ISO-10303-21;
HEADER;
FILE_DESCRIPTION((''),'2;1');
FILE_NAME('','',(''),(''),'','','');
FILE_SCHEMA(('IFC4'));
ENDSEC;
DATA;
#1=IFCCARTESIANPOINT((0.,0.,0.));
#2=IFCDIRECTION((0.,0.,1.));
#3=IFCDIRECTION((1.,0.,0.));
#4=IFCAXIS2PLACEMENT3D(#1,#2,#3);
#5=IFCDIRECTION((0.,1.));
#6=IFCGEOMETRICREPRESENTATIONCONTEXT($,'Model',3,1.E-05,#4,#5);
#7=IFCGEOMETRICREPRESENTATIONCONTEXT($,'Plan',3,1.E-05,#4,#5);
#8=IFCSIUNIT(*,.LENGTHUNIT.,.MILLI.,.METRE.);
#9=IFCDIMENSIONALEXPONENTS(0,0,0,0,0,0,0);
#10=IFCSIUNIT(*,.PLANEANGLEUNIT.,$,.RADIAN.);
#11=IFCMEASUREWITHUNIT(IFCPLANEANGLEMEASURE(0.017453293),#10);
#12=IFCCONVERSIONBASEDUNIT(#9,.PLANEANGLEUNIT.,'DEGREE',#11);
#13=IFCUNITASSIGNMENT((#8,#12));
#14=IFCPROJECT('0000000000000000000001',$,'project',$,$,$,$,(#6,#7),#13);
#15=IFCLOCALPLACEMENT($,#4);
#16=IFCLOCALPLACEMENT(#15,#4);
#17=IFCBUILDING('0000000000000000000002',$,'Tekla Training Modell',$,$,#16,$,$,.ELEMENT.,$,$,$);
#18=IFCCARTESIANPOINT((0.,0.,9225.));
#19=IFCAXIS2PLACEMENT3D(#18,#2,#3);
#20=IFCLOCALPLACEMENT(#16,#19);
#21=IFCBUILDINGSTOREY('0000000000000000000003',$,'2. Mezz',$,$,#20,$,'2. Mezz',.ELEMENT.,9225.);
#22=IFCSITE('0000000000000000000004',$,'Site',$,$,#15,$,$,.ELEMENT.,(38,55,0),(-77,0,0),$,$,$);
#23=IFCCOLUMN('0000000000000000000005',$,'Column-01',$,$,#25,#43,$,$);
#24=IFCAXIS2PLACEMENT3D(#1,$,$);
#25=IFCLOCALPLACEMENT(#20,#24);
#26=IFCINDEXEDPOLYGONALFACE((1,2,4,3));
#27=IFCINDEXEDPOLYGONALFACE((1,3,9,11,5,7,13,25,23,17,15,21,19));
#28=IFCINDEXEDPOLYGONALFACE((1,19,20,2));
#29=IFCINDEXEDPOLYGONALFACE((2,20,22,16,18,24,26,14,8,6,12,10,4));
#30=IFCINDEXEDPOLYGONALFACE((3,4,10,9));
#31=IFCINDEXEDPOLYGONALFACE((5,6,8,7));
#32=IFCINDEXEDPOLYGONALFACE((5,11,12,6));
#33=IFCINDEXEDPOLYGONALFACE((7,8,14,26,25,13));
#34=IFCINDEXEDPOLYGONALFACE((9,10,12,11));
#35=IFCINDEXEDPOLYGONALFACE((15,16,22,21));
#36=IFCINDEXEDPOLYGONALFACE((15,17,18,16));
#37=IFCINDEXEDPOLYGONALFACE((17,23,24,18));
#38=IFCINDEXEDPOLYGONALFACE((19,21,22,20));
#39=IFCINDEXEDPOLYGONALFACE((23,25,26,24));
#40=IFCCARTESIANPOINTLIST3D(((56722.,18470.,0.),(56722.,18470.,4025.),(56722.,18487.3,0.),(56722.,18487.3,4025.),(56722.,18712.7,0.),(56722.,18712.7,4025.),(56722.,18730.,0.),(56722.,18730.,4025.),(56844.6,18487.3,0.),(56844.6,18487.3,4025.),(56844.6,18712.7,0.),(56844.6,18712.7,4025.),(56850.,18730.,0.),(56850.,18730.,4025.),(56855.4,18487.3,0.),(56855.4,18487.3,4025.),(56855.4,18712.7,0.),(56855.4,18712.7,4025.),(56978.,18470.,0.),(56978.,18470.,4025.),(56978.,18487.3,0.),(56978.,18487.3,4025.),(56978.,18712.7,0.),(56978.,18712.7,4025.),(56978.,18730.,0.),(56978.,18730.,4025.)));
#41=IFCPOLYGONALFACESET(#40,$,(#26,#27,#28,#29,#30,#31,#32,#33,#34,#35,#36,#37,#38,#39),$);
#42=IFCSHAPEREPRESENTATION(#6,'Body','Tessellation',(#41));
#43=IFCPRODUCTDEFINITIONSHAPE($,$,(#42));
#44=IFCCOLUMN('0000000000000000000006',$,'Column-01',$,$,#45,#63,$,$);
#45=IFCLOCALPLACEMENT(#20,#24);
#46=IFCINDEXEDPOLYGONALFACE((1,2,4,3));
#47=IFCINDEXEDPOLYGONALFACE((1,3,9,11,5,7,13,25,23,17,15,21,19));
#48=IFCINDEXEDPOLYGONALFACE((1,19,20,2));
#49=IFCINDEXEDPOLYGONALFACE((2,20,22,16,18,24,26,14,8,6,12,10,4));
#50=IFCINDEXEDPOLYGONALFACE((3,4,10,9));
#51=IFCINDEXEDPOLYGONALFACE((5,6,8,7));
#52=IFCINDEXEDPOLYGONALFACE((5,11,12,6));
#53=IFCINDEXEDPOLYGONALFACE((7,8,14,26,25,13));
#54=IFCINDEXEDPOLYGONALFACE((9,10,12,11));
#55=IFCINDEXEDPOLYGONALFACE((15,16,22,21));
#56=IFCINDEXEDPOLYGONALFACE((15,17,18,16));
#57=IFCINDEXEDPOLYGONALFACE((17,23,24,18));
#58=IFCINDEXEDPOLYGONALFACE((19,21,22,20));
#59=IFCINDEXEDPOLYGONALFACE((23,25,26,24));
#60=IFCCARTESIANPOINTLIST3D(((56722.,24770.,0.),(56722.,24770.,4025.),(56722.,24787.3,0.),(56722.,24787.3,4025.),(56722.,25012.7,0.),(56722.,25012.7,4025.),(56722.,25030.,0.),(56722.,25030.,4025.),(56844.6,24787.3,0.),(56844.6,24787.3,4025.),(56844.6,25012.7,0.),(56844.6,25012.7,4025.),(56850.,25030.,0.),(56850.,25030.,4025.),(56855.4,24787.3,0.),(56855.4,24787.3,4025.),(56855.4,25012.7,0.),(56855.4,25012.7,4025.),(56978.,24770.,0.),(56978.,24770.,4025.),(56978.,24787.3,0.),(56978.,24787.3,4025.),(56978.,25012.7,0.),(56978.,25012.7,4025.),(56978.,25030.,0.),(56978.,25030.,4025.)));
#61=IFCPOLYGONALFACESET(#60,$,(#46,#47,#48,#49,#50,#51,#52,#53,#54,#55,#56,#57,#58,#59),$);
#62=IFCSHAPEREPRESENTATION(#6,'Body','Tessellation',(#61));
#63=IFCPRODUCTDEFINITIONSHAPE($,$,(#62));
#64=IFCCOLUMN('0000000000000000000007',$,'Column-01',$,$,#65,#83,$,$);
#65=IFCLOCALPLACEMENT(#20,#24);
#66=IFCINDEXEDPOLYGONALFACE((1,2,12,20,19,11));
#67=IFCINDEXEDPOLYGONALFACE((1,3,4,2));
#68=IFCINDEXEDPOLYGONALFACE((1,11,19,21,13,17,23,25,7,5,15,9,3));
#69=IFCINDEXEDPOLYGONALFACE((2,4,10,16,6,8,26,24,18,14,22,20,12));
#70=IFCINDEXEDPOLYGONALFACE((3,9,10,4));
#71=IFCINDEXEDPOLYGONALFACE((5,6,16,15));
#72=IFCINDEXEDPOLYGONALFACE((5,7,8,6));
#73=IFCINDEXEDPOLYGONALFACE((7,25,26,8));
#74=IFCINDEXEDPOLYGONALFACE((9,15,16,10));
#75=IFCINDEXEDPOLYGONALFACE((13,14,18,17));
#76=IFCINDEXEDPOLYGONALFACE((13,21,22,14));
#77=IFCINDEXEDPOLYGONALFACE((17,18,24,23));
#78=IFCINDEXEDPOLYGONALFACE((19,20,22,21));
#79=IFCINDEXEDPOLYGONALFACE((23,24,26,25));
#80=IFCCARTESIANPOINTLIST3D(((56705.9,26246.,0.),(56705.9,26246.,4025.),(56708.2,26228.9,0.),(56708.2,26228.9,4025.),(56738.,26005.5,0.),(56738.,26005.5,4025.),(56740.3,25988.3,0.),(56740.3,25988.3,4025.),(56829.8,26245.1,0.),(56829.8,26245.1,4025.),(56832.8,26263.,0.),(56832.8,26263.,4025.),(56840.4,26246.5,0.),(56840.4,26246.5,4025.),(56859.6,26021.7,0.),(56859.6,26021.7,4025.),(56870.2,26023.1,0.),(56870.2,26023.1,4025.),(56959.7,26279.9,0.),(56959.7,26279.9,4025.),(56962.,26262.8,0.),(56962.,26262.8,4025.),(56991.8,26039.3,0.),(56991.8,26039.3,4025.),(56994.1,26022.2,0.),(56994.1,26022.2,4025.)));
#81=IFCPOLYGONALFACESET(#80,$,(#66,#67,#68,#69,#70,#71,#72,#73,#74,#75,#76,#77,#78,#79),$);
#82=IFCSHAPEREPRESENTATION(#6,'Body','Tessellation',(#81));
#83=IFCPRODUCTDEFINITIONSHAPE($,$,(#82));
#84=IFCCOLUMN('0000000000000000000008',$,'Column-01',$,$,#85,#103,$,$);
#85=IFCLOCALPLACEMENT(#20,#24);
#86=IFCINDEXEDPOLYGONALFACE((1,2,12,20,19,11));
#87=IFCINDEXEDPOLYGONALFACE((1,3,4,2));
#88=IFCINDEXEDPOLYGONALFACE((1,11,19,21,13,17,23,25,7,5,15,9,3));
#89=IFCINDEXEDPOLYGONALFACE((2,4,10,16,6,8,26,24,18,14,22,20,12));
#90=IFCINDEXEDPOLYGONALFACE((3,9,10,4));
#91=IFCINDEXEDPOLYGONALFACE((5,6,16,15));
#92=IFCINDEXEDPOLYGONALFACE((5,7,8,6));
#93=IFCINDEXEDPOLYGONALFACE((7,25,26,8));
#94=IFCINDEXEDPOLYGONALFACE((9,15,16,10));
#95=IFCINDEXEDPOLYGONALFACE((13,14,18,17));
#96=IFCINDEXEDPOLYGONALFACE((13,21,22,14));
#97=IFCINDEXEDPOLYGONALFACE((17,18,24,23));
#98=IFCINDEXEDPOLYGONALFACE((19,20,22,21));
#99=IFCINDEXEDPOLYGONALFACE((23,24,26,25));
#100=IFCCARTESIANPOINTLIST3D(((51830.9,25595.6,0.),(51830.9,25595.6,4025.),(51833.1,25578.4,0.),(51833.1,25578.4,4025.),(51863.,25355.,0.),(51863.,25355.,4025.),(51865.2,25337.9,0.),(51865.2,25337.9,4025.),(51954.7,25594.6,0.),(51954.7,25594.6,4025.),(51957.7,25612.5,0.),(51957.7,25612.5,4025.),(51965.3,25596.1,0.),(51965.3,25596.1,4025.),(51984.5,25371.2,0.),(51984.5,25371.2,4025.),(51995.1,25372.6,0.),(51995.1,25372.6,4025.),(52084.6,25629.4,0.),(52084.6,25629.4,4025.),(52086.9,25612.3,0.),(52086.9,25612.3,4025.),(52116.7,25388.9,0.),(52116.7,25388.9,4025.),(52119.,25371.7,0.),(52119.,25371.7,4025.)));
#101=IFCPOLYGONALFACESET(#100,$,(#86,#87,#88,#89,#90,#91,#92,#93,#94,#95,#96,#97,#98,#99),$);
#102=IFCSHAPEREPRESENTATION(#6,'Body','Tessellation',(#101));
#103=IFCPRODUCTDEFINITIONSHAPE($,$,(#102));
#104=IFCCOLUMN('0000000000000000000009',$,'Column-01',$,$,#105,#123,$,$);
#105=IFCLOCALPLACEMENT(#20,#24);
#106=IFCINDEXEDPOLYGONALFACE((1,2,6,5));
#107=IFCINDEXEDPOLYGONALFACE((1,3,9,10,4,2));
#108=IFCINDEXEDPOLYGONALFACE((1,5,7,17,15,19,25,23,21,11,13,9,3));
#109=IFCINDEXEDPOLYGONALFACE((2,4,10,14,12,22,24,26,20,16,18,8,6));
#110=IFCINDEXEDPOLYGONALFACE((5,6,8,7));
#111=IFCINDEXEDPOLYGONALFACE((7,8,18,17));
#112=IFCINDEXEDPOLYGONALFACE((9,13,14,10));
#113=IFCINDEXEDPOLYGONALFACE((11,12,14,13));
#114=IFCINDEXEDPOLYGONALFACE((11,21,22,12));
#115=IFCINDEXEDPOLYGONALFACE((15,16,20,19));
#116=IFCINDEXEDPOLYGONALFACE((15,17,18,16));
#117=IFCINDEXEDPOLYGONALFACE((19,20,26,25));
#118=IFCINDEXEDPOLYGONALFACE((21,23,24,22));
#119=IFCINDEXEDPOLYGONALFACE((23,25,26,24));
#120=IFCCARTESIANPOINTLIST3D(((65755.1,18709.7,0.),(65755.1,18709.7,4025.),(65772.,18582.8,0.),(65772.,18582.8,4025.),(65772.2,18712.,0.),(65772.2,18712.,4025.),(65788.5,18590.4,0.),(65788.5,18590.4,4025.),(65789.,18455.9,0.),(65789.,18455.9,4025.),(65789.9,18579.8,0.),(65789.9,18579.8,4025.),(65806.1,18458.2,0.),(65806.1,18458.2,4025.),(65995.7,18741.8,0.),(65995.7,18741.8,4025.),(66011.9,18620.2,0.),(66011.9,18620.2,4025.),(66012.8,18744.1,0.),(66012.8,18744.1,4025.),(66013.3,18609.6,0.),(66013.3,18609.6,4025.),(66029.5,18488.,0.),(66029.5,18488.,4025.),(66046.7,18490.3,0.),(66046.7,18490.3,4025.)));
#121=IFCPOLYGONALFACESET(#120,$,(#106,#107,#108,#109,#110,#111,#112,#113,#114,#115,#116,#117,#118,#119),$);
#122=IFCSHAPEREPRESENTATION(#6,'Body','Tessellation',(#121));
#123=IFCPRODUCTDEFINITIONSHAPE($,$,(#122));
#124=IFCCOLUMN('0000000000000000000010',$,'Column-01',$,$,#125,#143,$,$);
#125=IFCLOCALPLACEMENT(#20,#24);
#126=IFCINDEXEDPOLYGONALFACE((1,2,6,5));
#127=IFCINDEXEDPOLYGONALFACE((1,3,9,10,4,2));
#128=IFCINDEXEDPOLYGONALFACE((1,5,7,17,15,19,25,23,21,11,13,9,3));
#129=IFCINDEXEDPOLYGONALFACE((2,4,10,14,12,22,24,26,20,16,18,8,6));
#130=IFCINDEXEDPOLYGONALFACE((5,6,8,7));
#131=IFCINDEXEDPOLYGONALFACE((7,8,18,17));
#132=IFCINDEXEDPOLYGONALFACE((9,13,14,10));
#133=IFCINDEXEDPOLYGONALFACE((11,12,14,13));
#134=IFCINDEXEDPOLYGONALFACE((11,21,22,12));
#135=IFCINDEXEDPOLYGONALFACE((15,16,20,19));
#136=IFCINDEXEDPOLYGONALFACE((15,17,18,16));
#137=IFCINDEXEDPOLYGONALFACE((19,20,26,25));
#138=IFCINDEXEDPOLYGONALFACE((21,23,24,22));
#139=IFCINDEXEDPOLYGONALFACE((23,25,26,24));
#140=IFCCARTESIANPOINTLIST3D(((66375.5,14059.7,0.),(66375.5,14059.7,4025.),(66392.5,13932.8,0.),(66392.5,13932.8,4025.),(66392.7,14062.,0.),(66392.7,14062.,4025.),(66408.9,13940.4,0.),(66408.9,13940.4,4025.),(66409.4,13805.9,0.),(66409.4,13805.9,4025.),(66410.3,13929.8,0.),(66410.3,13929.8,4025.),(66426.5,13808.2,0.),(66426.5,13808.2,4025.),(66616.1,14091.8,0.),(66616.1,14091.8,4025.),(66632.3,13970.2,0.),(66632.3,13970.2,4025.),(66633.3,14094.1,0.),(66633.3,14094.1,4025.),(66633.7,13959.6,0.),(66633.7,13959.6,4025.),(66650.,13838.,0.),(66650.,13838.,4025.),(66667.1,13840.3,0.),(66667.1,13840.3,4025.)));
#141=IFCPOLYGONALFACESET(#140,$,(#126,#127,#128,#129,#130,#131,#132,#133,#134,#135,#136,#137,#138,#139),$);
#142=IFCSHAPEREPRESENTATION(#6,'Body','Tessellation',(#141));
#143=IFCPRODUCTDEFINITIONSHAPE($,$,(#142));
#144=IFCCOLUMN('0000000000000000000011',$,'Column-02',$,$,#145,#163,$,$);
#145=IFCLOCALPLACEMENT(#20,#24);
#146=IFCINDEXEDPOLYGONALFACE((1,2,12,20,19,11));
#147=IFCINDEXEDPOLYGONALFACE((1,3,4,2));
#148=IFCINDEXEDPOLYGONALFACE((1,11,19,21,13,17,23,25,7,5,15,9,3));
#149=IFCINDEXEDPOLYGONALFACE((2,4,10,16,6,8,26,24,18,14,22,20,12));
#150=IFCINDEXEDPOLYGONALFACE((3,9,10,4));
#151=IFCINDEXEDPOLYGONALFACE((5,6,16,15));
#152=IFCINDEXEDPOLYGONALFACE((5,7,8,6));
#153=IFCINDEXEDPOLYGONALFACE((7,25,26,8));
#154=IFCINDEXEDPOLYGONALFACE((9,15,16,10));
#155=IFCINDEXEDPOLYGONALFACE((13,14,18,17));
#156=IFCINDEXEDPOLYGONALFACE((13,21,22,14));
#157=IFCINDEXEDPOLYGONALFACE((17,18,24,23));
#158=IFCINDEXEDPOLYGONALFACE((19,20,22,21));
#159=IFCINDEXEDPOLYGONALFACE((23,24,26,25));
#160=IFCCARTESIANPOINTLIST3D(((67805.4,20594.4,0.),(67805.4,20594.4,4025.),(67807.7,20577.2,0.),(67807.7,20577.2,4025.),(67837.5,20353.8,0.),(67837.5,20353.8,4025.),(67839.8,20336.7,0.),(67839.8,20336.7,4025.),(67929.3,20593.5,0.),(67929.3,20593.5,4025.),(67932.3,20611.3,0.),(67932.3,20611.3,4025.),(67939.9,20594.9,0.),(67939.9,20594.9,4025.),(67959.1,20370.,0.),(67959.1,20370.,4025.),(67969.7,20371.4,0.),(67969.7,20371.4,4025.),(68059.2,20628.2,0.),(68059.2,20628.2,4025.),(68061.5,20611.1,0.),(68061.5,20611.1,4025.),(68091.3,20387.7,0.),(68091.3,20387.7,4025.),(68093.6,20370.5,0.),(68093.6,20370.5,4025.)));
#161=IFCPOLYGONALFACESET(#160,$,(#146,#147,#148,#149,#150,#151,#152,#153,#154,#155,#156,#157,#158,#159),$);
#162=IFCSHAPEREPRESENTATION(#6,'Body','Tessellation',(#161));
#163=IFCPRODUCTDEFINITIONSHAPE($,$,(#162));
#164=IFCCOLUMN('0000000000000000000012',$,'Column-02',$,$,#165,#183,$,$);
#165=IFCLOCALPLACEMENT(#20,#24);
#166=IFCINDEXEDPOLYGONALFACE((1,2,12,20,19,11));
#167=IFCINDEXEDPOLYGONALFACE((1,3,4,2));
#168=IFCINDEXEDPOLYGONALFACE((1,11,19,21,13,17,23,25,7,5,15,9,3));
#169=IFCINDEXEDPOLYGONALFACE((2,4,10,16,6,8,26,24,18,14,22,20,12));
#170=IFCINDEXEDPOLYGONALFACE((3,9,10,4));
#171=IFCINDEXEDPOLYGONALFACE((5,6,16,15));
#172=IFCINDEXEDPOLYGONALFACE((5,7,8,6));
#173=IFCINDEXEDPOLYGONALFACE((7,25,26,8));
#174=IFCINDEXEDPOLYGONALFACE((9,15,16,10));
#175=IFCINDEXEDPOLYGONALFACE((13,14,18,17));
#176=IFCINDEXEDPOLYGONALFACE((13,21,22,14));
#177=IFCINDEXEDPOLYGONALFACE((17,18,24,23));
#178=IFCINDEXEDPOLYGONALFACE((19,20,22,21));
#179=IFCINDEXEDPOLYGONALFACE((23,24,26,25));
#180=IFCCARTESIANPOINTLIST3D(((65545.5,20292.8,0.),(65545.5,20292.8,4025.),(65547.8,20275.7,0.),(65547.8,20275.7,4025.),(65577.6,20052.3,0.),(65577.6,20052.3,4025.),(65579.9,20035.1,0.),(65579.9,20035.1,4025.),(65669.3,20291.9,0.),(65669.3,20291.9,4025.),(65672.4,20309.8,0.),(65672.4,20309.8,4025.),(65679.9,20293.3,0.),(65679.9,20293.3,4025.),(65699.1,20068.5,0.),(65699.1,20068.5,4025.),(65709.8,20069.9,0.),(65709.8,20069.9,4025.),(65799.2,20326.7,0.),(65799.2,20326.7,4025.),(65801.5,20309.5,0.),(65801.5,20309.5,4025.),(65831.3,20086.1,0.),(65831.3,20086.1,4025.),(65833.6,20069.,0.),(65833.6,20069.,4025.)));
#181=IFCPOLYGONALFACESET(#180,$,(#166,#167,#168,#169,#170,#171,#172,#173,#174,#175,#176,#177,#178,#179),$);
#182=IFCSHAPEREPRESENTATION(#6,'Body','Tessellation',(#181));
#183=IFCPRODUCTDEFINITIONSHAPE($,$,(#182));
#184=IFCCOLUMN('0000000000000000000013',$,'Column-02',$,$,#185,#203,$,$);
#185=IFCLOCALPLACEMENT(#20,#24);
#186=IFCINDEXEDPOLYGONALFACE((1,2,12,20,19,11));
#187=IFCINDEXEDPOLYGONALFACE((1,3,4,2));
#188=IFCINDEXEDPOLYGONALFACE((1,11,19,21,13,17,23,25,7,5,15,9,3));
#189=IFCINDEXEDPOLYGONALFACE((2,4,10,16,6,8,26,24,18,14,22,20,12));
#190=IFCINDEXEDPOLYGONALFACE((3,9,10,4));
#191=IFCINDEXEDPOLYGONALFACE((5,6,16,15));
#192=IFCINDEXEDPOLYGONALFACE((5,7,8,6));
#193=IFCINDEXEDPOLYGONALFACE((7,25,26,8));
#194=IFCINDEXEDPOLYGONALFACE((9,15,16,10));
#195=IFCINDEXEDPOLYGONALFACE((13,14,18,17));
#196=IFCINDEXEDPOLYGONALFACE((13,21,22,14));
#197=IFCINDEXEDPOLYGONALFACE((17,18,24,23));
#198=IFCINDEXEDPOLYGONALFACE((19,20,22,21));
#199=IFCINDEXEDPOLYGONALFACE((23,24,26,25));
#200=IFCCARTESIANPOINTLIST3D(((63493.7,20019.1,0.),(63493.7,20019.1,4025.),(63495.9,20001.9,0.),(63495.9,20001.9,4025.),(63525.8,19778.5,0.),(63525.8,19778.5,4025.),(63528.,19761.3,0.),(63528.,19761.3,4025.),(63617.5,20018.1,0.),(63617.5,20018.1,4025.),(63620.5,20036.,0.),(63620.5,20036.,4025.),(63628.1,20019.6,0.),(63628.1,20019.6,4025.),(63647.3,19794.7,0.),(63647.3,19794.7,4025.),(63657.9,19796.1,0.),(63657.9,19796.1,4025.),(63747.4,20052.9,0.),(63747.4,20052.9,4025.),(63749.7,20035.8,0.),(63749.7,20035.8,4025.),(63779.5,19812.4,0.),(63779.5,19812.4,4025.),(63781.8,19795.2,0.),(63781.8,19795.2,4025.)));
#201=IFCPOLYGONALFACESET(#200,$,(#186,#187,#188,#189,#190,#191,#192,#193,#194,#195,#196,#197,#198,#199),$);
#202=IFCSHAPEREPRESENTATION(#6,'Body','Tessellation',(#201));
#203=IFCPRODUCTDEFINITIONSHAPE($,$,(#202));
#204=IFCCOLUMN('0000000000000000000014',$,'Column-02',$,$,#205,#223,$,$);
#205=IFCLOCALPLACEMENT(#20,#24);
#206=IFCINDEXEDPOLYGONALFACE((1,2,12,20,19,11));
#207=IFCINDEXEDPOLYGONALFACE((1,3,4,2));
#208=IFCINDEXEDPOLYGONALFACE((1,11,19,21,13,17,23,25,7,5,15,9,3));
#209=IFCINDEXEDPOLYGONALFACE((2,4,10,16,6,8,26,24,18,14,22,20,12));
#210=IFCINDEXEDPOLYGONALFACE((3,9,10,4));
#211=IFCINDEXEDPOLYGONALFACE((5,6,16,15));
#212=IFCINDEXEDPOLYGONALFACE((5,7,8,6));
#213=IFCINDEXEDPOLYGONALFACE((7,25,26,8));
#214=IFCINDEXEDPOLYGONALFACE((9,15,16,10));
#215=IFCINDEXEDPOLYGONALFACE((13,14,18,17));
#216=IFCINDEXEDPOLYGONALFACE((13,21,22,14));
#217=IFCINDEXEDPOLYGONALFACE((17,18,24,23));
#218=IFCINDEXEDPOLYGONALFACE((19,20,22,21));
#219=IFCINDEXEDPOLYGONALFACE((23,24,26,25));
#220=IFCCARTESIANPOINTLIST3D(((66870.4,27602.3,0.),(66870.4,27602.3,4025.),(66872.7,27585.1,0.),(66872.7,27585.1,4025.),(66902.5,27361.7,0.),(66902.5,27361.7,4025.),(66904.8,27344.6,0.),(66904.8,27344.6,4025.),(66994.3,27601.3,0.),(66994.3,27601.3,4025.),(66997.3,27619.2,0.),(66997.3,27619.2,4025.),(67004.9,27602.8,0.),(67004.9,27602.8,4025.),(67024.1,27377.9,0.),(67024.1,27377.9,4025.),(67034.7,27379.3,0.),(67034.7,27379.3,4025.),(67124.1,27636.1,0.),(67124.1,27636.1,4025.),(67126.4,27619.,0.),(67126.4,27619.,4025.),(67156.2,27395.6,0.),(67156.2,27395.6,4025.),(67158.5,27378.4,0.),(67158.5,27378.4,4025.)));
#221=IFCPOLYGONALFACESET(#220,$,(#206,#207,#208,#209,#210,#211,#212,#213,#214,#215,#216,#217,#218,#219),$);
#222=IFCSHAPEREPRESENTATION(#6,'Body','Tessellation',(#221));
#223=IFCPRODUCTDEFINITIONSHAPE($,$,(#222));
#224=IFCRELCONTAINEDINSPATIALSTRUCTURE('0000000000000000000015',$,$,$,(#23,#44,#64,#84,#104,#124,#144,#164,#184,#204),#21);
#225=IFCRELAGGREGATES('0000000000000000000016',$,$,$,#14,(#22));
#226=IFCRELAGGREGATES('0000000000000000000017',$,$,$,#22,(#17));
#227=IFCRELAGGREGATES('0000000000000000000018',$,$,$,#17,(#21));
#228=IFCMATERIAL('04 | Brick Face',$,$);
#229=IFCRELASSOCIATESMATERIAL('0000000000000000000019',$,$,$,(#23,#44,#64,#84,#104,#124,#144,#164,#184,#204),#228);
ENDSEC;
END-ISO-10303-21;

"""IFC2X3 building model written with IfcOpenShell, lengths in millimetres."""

from ifc_helpers import new_model, entity, si_unit, converted_unit, direction, frame, origin_with_axes, place, context, project, spatial, polyline, outline, extrude, material, element, save


model = new_model("IFC2X3")

# Units and contexts
model_context = context("Model", 3, precision=1e-05, world=origin_with_axes(), true_north=direction((0.0, 1.0)))
plan_context = context("Plan", 3, precision=1e-05, world=origin_with_axes(), true_north=direction((0.0, 1.0)))
ifc_project = project(units=[si_unit("LENGTHUNIT", "METRE", prefix="MILLI"), converted_unit("PLANEANGLEUNIT", "DEGREE", entity("IfcPlaneAngleMeasure", 0.017453293), si_unit("PLANEANGLEUNIT", "RADIAN"), dimensions=[0, 0, 0, 0, 0, 0, 0])], contexts=[model_context, plan_context])

# Site, building, storey
site_placement = place(None, origin_with_axes())
site = spatial("IfcSite", under=ifc_project, at=site_placement, Name="Site", CompositionType="ELEMENT", RefLatitude=(38, 55, 0), RefLongitude=(-77, 0, 0))
building_placement = place(site_placement, origin_with_axes())
building = spatial("IfcBuilding", under=site, at=building_placement, Name="Tekla Training Modell", CompositionType="ELEMENT")
storey_placement = place(building_placement, frame((0.0, 0.0, 9225.0), z_axis=(0.0, 0.0, 1.0), x_axis=(1.0, 0.0, 0.0)))
storey = spatial("IfcBuildingStorey", under=building, at=storey_placement, Name="2. Mezz", LongName="2. Mezz", CompositionType="ELEMENT", Elevation=9225.0)

# Columns
ifc_material_1 = material(Name="04 | Brick Face")
for number, where, z_axis, x_axis, name in (
    (1, (56850.0, 18600.0, 0.0), (0.0, 0.0, 1.0), (1.0, 0.0, 0.0), "Column-01"),
    (2, (56850.0, 24900.0, 0.0), (0.0, 0.0, 1.0), (1.0, 0.0, 0.0), "Column-01"),
    (3, (56850.0, 26134.1, 0.0), (0.0, 0.0, 1.0), (0.991216, 0.132256, 0.0), "Column-01"),
    (4, (51974.9, 25483.6, 0.0), (0.0, 0.0, 1.0), (0.991216, 0.132256, 0.0), "Column-01"),
    (5, (65900.9, 18600.0, 0.0), (0.0, 0.0, 1.0), (-0.132256, 0.991216, 0.0), "Column-01"),
    (6, (66521.3, 13950.0, 0.0), (0.0, 0.0, 1.0), (-0.132256, 0.991216, 0.0), "Column-01"),
    (7, (67949.5, 20482.5, 0.0), (0.0, 0.0, 1.0), (0.991216, 0.132256, 0.0), "Column-02"),
    (8, (65689.5, 20180.9, 0.0), (0.0, 0.0, 1.0), (0.991216, 0.132256, 0.0), "Column-02"),
    (9, (63637.7, 19907.1, 0.0), (0.0, 0.0, 1.0), (0.991216, 0.132256, 0.0), "Column-02"),
    (10, (67014.5, 27490.3, 0.0), (0.0, 0.0, 1.0), (0.991216, 0.132256, 0.0), "Column-02"),
):
    element("IfcColumn", number, at=place(storey_placement, frame(where, z_axis=z_axis, x_axis=x_axis)), inside=storey, material=ifc_material_1, Name=name, context=model_context, shape_type="SweptSolid", body=[
        extrude(outline(polyline([(0.0, 130.0), (-128.0, 130.0), (-128.0, 112.7), (-5.3, 112.7), (-5.3, -112.7), (-128.0, -112.7), (-128.0, -130.0), (128.0, -130.0), (128.0, -112.7), (5.3, -112.7), (5.3, 112.7), (128.0, 112.7), (128.0, 130.0), (0.0, 130.0)])), origin_with_axes(), (0.0, 0.0, 1.0), 4025.0),
    ])

save(model, "model.ifc")
